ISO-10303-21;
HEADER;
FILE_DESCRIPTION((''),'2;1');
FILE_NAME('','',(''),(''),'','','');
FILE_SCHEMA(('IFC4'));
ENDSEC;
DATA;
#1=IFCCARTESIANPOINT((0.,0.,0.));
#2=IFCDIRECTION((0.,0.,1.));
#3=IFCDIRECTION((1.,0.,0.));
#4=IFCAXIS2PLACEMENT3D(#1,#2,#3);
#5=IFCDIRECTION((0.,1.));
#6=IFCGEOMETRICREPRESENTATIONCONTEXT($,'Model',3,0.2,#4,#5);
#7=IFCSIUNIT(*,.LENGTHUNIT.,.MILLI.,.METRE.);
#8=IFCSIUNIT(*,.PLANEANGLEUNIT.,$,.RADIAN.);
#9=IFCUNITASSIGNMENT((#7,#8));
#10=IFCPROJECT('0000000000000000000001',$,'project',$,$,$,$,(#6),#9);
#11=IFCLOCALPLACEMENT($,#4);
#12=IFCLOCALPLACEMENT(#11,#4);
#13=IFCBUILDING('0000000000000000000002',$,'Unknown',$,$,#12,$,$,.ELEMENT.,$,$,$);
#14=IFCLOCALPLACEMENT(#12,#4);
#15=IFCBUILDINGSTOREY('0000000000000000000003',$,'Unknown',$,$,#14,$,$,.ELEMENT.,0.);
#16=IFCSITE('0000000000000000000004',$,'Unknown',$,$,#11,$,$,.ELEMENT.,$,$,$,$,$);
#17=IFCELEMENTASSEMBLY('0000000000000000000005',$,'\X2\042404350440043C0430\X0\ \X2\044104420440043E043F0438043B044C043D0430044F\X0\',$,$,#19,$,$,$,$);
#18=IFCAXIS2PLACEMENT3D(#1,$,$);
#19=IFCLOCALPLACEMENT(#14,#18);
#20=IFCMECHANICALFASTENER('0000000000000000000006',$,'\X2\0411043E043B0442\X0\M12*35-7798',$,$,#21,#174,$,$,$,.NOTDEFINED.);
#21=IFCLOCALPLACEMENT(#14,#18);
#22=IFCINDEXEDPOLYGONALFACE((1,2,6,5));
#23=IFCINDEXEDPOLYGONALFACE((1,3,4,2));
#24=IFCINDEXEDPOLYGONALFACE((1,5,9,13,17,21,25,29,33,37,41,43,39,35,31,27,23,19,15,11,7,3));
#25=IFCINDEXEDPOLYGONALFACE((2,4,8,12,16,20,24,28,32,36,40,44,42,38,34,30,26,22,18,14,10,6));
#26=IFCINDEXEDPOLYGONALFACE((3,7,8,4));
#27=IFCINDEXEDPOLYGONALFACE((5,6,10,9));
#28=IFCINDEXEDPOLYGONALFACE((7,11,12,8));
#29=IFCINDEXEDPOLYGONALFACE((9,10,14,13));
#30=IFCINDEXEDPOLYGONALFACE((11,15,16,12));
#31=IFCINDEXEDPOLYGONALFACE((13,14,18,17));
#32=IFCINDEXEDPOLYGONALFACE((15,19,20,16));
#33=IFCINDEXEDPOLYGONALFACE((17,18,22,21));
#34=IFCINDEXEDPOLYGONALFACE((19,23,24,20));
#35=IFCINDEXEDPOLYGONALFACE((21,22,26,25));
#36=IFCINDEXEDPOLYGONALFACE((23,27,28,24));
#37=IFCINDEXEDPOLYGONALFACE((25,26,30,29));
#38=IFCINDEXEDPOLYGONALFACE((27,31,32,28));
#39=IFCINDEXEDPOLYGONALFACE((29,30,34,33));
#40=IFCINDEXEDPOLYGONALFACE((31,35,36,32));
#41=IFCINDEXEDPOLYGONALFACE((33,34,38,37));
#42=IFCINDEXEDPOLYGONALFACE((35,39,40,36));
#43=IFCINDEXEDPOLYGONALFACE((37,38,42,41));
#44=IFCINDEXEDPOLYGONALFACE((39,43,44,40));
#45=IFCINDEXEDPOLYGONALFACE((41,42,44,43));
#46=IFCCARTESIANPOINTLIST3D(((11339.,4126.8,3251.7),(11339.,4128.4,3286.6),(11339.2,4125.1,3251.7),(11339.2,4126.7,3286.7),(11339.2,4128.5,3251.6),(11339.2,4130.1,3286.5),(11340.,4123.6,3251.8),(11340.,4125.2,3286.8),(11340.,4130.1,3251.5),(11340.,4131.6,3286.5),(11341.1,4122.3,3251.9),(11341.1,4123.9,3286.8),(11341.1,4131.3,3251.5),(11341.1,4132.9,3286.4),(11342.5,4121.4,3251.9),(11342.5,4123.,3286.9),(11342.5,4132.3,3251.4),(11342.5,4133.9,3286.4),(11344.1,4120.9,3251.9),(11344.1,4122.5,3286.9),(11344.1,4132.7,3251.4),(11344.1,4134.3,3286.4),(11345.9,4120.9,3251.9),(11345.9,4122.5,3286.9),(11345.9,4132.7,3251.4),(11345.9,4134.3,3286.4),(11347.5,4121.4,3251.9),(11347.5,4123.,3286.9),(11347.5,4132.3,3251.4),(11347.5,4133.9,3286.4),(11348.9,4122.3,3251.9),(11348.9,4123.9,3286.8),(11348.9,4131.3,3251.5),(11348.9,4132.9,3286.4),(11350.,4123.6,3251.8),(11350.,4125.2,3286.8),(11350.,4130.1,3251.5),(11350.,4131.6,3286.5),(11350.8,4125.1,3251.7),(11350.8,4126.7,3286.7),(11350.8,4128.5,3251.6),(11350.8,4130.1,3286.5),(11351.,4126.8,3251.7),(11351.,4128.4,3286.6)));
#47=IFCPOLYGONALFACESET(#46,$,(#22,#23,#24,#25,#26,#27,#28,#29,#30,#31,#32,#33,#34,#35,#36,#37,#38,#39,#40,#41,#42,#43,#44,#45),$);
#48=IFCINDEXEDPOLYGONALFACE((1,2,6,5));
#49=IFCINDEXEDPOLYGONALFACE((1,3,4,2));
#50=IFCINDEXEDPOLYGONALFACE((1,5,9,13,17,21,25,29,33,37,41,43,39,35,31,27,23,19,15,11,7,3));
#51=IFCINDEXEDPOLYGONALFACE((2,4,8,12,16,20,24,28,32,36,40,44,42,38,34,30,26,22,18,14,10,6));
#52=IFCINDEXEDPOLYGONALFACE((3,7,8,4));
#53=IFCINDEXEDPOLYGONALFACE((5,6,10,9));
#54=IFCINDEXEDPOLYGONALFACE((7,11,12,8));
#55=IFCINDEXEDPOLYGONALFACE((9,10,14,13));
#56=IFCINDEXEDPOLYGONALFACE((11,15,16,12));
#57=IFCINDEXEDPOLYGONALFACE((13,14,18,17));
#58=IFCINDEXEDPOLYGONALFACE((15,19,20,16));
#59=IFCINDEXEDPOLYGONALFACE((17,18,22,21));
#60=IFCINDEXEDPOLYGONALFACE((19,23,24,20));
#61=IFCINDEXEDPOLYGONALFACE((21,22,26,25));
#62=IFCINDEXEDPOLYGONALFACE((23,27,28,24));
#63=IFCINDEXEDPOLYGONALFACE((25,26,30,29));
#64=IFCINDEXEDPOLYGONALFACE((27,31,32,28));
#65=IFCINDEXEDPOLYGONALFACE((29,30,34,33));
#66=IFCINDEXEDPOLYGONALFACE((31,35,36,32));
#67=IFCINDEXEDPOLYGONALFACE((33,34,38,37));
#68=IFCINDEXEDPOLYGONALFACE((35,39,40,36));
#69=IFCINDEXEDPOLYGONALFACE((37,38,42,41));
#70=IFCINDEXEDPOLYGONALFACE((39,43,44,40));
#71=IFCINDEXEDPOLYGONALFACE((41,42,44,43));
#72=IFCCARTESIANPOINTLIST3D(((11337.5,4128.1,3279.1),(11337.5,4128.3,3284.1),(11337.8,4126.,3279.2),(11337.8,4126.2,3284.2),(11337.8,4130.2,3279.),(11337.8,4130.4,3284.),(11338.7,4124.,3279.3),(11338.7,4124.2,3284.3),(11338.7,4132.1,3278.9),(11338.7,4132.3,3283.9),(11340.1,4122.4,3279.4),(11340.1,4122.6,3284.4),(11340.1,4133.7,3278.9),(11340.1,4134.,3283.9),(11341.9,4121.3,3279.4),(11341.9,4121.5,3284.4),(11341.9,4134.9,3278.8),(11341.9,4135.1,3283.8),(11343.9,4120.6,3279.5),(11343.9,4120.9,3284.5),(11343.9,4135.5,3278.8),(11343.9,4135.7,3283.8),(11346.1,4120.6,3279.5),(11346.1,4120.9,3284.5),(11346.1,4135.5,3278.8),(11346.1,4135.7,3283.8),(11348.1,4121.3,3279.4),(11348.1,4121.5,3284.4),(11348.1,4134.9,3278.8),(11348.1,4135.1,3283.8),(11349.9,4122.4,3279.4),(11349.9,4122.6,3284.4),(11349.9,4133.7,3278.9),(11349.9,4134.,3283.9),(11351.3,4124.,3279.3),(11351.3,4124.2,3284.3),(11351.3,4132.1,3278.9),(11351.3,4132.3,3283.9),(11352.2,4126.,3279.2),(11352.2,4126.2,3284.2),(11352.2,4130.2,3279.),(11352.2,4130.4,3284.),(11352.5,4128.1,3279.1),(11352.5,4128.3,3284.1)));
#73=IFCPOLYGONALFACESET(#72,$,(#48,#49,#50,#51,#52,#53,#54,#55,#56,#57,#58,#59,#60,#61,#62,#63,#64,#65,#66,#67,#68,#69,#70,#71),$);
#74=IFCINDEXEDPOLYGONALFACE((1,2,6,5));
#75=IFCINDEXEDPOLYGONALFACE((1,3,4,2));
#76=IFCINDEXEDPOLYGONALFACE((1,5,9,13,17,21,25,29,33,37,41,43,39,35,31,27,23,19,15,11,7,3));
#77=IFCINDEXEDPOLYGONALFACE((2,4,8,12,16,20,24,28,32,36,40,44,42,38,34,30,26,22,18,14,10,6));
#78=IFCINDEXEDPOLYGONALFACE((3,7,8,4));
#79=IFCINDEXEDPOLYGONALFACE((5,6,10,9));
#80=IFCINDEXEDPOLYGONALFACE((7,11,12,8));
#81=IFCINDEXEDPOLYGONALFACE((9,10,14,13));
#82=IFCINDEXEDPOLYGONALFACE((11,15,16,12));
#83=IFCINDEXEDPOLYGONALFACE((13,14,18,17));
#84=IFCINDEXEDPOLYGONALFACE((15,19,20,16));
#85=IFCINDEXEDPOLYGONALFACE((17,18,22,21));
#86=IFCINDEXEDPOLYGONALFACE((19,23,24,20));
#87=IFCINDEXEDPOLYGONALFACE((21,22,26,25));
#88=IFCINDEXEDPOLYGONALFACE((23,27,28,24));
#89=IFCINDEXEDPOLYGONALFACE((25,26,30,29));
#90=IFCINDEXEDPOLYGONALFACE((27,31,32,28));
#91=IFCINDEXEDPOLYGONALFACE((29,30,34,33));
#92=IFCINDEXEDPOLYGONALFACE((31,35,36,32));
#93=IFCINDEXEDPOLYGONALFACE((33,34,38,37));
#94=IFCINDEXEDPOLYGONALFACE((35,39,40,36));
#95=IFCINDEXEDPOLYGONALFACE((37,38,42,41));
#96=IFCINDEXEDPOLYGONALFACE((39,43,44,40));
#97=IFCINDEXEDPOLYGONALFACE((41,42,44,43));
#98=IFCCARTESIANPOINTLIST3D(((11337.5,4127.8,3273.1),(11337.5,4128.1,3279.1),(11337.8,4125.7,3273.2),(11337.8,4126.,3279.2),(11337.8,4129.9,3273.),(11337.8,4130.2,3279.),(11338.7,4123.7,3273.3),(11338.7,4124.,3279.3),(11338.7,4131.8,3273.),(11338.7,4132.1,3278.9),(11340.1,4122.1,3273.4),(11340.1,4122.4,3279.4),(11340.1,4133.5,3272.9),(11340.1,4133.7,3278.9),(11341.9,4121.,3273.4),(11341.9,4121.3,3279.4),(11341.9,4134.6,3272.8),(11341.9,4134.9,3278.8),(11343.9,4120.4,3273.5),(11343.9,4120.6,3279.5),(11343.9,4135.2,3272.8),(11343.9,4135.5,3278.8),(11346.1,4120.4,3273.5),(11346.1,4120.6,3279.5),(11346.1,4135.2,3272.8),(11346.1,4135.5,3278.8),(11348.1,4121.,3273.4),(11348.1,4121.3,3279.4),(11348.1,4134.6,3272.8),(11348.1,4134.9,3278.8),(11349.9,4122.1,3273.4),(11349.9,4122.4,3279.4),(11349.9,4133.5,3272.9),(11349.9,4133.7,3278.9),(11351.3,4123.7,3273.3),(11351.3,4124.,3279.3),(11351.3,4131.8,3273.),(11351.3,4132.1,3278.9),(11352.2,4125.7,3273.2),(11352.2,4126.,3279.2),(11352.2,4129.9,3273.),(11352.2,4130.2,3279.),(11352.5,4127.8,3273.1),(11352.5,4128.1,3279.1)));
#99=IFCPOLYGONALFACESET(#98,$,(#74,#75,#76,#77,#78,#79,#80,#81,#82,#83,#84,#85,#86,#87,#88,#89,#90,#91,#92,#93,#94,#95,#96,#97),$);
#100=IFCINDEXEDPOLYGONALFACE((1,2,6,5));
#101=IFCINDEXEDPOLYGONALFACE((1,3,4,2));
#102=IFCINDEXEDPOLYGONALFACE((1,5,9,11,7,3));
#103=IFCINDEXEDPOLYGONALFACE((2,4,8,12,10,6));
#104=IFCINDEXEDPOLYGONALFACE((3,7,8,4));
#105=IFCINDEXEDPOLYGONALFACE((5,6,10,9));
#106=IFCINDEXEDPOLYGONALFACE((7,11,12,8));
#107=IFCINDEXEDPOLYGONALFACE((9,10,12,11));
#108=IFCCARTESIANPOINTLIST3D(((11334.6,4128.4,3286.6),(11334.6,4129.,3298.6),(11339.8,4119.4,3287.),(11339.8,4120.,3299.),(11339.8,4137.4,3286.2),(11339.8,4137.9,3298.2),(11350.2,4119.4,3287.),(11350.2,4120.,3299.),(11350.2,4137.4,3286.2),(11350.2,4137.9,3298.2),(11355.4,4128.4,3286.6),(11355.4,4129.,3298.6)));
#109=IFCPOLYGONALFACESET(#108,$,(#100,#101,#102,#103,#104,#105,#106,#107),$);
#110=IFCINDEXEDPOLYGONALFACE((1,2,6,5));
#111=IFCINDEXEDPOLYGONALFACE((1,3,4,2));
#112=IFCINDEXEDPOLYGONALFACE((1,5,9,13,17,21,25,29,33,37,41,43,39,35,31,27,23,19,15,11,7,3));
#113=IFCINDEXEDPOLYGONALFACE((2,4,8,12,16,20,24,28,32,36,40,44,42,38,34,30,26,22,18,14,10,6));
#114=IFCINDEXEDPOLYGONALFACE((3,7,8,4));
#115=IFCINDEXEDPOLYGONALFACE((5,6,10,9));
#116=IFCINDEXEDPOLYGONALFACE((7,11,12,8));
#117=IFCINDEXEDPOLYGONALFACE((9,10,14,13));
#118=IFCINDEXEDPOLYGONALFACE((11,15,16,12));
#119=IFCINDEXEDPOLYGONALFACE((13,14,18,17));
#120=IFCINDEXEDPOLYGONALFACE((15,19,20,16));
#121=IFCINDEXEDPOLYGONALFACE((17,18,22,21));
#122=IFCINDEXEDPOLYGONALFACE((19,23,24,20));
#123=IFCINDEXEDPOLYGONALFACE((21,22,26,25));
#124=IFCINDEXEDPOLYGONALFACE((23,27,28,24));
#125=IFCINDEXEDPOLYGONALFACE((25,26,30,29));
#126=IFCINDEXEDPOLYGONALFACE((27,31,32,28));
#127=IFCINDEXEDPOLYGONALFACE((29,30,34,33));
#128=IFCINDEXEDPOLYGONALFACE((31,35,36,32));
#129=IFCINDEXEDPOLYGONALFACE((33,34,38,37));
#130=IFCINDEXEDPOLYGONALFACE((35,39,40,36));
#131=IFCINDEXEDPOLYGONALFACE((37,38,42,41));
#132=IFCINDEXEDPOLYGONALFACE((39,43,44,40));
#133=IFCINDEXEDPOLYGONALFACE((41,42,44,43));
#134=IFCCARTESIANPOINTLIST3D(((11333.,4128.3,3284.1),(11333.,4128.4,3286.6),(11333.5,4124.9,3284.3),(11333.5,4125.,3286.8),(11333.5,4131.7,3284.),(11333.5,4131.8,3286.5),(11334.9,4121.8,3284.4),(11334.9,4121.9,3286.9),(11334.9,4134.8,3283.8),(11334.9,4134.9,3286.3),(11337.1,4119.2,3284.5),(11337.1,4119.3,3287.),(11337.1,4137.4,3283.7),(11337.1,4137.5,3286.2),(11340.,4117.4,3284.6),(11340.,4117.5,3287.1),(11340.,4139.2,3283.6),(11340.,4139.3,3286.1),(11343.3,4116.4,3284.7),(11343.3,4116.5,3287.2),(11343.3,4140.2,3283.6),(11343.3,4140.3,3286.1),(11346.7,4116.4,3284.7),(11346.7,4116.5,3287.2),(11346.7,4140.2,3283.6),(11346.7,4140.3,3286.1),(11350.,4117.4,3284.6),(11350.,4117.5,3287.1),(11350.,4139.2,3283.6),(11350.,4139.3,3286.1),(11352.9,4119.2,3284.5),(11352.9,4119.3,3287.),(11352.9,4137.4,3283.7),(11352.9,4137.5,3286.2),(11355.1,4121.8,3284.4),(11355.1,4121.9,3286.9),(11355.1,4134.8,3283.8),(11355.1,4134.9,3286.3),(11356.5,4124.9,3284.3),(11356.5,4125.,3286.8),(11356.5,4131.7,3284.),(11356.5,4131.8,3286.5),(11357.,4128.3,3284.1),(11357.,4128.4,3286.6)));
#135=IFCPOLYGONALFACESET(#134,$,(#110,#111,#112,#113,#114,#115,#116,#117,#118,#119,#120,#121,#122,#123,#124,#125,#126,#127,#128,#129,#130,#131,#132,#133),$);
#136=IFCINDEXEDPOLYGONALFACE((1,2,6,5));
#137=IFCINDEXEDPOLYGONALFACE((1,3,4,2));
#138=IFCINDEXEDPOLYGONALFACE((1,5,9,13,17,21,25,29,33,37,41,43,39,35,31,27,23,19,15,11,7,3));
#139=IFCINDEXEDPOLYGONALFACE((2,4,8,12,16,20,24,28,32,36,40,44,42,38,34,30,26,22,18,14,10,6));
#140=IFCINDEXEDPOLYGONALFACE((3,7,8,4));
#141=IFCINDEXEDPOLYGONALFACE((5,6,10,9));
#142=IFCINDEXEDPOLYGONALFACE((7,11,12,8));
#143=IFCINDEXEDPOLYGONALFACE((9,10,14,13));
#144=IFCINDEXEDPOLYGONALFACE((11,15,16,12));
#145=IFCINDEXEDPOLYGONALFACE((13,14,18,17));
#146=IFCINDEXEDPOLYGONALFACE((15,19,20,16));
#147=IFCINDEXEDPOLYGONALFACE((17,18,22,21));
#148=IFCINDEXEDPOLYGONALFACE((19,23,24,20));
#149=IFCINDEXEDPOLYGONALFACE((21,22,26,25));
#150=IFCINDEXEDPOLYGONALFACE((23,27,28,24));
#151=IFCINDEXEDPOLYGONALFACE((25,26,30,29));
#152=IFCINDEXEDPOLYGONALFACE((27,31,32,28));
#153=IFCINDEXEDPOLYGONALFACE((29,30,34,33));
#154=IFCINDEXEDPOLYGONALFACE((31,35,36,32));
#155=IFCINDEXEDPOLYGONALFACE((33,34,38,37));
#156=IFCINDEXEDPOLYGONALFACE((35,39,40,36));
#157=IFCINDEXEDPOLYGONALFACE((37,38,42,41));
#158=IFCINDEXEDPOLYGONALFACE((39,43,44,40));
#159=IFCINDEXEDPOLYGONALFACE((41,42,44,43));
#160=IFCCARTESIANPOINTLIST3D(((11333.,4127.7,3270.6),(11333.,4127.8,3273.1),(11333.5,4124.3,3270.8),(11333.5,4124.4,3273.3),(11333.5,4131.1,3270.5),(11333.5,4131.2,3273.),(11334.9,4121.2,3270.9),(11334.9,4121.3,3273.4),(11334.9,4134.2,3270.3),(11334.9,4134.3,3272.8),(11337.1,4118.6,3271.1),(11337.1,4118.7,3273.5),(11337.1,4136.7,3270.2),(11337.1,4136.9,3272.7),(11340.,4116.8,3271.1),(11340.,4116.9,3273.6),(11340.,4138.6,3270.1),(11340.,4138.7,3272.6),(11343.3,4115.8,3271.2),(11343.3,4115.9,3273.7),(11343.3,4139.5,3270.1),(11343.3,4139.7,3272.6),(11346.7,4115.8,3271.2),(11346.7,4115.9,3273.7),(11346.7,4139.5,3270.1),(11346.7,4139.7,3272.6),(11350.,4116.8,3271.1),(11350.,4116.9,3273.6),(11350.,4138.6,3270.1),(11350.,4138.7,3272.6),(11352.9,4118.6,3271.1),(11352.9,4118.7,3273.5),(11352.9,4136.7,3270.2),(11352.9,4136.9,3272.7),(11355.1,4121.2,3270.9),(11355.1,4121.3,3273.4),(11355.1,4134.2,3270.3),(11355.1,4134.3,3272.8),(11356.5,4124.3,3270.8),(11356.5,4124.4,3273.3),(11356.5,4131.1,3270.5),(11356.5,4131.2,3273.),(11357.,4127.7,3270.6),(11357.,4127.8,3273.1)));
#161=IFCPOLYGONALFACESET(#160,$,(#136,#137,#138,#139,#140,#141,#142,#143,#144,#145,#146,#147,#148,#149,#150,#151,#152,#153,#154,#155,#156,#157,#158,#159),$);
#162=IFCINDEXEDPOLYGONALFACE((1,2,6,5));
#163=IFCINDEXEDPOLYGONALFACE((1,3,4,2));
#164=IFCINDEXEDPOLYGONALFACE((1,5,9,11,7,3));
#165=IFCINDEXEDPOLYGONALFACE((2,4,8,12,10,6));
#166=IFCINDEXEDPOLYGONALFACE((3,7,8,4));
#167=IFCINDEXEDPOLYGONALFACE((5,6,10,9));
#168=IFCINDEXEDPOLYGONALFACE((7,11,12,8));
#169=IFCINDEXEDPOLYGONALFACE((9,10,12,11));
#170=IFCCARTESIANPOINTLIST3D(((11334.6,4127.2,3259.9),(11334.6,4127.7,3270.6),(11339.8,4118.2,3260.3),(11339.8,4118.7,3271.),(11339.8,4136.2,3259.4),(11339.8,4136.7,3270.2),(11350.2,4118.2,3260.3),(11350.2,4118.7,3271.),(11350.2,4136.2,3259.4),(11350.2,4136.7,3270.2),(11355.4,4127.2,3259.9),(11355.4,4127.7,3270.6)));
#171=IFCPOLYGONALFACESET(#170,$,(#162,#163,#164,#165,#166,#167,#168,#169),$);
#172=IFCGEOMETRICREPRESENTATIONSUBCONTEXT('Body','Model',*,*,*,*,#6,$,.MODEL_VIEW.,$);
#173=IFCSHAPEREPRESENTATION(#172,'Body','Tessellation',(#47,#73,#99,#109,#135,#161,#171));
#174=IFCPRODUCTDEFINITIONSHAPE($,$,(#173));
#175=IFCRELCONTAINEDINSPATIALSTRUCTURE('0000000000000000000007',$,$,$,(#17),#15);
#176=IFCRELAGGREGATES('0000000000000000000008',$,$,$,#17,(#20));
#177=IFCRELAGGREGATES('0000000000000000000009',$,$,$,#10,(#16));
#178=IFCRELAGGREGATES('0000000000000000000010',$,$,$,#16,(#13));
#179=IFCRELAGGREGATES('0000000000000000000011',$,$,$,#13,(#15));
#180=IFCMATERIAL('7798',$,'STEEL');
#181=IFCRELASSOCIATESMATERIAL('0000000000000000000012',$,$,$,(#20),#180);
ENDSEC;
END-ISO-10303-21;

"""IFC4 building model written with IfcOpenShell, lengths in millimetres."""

from ifc_helpers import new_model, si_unit, direction, frame, origin_with_axes, place, context, subcontext, project, spatial, line, arc, indexed_curve, outline, extrude, source, transform, mapped, material, element, aggregate, save


model = new_model("IFC4")

# Units and contexts
model_context = context("Model", 3, precision=0.2, world=origin_with_axes(), true_north=direction((0.0, 1.0)))
body_context = subcontext(model_context, "Body", "Model", "MODEL_VIEW")
ifc_project = project(units=[si_unit("LENGTHUNIT", "METRE", prefix="MILLI"), si_unit("PLANEANGLEUNIT", "RADIAN")], contexts=[model_context])

# Site, building, storey
site_placement = place(None, origin_with_axes())
site = spatial("IfcSite", under=ifc_project, at=site_placement, Name="Unknown", CompositionType="ELEMENT")
building_placement = place(site_placement, origin_with_axes())
building = spatial("IfcBuilding", under=site, at=building_placement, Name="Unknown", CompositionType="ELEMENT")
storey_placement = place(building_placement, origin_with_axes())
storey = spatial("IfcBuildingStorey", under=building, at=storey_placement, Name="Unknown", CompositionType="ELEMENT", Elevation=0.0)

# Element assembly
assembly_1_placement = place(storey_placement, frame((11400.0, 88.6, 3426.7), z_axis=(1.0, 0.0, 0.0), x_axis=(0.0, 0.998969, -0.045408)))
assembly_1 = element("IfcElementAssembly", 1, at=assembly_1_placement, inside=storey, Name="Ферма стропильная")

# Mechanical fastener
ifc_material_1 = material(Name="7798", Category="STEEL")
shared_shape_1 = source(origin_with_axes(), body_context, "Body", "SweptSolid", [
    extrude(outline(indexed_curve([(6.0, 0.0), (0.0, 6.0), (-6.0, 0.0), (0.0, -6.0)], segments=[arc(1, 2, 3), arc(3, 4, 1)])), frame((0.0, 0.0, 7.5), z_axis=(0.0, 0.0, -1.0), x_axis=(0.0, 1.0, 0.0)), (0.0, 0.0, 1.0), 35.0),
    extrude(outline(indexed_curve([(7.5, 0.0), (0.0, 7.5), (-7.5, 0.0), (0.0, -7.5)], segments=[arc(1, 2, 3), arc(3, 4, 1)])), frame((0.0, 0.0, 5.0), z_axis=(0.0, 0.0, -1.0), x_axis=(0.0, 1.0, 0.0)), (0.0, 0.0, 1.0), 5.0),
    extrude(outline(indexed_curve([(7.5, 0.0), (0.0, 7.5), (-7.5, 0.0), (0.0, -7.5)], segments=[arc(1, 2, 3), arc(3, 4, 1)])), frame((0.0, 0.0, 0.0), z_axis=(0.0, 0.0, -1.0), x_axis=(0.0, 1.0, 0.0)), (0.0, 0.0, 1.0), 6.0),
    extrude(outline(indexed_curve([(10.4, 0.0), (5.2, 9.0), (-5.2, 9.0), (-10.4, 0.0), (-5.2, -9.0), (5.2, -9.0)], segments=[line(1, 2, 3, 4, 5, 6, 1)])), frame((0.0, 0.0, 19.5), z_axis=(0.0, 0.0, -1.0), x_axis=(0.0, 1.0, 0.0)), (0.0, 0.0, 1.0), 12.0),
    extrude(outline(indexed_curve([(12.0, 0.0), (0.0, 12.0), (-12.0, 0.0), (0.0, -12.0)], segments=[arc(1, 2, 3), arc(3, 4, 1)])), frame((0.0, 0.0, 7.5), z_axis=(0.0, 0.0, -1.0), x_axis=(0.0, 1.0, 0.0)), (0.0, 0.0, 1.0), 2.5),
    extrude(outline(indexed_curve([(12.0, 0.0), (0.0, 12.0), (-12.0, 0.0), (0.0, -12.0)], segments=[arc(1, 2, 3), arc(3, 4, 1)])), frame((0.0, 0.0, -6.0), z_axis=(0.0, 0.0, -1.0), x_axis=(0.0, 1.0, 0.0)), (0.0, 0.0, 1.0), 2.5),
    extrude(outline(indexed_curve([(10.4, 0.0), (5.2, 9.0), (-5.2, 9.0), (-10.4, 0.0), (-5.2, -9.0), (5.2, -9.0)], segments=[line(1, 2, 3, 4, 5, 6, 1)])), frame((0.0, 0.0, -8.5), z_axis=(0.0, 0.0, -1.0), x_axis=(0.0, 1.0, 0.0)), (0.0, 0.0, 1.0), 10.8),
])
mechanical_fastener_1_placement = place(assembly_1_placement, frame((4042.0, 36.0, -55.0), z_axis=(0.0, 1.0, 0.0), x_axis=(1.0, 0.0, 0.0)))
mechanical_fastener_1 = element("IfcMechanicalFastener", 2, at=mechanical_fastener_1_placement, material=ifc_material_1, Name="БолтM12*35-7798", PredefinedType="NOTDEFINED", context=body_context, shape_type="MappedRepresentation", body=[
    mapped(shared_shape_1, transform((0.0, 0.0, 0.0))),
])
aggregate(assembly_1, [mechanical_fastener_1])

save(model, "model.ifc")
